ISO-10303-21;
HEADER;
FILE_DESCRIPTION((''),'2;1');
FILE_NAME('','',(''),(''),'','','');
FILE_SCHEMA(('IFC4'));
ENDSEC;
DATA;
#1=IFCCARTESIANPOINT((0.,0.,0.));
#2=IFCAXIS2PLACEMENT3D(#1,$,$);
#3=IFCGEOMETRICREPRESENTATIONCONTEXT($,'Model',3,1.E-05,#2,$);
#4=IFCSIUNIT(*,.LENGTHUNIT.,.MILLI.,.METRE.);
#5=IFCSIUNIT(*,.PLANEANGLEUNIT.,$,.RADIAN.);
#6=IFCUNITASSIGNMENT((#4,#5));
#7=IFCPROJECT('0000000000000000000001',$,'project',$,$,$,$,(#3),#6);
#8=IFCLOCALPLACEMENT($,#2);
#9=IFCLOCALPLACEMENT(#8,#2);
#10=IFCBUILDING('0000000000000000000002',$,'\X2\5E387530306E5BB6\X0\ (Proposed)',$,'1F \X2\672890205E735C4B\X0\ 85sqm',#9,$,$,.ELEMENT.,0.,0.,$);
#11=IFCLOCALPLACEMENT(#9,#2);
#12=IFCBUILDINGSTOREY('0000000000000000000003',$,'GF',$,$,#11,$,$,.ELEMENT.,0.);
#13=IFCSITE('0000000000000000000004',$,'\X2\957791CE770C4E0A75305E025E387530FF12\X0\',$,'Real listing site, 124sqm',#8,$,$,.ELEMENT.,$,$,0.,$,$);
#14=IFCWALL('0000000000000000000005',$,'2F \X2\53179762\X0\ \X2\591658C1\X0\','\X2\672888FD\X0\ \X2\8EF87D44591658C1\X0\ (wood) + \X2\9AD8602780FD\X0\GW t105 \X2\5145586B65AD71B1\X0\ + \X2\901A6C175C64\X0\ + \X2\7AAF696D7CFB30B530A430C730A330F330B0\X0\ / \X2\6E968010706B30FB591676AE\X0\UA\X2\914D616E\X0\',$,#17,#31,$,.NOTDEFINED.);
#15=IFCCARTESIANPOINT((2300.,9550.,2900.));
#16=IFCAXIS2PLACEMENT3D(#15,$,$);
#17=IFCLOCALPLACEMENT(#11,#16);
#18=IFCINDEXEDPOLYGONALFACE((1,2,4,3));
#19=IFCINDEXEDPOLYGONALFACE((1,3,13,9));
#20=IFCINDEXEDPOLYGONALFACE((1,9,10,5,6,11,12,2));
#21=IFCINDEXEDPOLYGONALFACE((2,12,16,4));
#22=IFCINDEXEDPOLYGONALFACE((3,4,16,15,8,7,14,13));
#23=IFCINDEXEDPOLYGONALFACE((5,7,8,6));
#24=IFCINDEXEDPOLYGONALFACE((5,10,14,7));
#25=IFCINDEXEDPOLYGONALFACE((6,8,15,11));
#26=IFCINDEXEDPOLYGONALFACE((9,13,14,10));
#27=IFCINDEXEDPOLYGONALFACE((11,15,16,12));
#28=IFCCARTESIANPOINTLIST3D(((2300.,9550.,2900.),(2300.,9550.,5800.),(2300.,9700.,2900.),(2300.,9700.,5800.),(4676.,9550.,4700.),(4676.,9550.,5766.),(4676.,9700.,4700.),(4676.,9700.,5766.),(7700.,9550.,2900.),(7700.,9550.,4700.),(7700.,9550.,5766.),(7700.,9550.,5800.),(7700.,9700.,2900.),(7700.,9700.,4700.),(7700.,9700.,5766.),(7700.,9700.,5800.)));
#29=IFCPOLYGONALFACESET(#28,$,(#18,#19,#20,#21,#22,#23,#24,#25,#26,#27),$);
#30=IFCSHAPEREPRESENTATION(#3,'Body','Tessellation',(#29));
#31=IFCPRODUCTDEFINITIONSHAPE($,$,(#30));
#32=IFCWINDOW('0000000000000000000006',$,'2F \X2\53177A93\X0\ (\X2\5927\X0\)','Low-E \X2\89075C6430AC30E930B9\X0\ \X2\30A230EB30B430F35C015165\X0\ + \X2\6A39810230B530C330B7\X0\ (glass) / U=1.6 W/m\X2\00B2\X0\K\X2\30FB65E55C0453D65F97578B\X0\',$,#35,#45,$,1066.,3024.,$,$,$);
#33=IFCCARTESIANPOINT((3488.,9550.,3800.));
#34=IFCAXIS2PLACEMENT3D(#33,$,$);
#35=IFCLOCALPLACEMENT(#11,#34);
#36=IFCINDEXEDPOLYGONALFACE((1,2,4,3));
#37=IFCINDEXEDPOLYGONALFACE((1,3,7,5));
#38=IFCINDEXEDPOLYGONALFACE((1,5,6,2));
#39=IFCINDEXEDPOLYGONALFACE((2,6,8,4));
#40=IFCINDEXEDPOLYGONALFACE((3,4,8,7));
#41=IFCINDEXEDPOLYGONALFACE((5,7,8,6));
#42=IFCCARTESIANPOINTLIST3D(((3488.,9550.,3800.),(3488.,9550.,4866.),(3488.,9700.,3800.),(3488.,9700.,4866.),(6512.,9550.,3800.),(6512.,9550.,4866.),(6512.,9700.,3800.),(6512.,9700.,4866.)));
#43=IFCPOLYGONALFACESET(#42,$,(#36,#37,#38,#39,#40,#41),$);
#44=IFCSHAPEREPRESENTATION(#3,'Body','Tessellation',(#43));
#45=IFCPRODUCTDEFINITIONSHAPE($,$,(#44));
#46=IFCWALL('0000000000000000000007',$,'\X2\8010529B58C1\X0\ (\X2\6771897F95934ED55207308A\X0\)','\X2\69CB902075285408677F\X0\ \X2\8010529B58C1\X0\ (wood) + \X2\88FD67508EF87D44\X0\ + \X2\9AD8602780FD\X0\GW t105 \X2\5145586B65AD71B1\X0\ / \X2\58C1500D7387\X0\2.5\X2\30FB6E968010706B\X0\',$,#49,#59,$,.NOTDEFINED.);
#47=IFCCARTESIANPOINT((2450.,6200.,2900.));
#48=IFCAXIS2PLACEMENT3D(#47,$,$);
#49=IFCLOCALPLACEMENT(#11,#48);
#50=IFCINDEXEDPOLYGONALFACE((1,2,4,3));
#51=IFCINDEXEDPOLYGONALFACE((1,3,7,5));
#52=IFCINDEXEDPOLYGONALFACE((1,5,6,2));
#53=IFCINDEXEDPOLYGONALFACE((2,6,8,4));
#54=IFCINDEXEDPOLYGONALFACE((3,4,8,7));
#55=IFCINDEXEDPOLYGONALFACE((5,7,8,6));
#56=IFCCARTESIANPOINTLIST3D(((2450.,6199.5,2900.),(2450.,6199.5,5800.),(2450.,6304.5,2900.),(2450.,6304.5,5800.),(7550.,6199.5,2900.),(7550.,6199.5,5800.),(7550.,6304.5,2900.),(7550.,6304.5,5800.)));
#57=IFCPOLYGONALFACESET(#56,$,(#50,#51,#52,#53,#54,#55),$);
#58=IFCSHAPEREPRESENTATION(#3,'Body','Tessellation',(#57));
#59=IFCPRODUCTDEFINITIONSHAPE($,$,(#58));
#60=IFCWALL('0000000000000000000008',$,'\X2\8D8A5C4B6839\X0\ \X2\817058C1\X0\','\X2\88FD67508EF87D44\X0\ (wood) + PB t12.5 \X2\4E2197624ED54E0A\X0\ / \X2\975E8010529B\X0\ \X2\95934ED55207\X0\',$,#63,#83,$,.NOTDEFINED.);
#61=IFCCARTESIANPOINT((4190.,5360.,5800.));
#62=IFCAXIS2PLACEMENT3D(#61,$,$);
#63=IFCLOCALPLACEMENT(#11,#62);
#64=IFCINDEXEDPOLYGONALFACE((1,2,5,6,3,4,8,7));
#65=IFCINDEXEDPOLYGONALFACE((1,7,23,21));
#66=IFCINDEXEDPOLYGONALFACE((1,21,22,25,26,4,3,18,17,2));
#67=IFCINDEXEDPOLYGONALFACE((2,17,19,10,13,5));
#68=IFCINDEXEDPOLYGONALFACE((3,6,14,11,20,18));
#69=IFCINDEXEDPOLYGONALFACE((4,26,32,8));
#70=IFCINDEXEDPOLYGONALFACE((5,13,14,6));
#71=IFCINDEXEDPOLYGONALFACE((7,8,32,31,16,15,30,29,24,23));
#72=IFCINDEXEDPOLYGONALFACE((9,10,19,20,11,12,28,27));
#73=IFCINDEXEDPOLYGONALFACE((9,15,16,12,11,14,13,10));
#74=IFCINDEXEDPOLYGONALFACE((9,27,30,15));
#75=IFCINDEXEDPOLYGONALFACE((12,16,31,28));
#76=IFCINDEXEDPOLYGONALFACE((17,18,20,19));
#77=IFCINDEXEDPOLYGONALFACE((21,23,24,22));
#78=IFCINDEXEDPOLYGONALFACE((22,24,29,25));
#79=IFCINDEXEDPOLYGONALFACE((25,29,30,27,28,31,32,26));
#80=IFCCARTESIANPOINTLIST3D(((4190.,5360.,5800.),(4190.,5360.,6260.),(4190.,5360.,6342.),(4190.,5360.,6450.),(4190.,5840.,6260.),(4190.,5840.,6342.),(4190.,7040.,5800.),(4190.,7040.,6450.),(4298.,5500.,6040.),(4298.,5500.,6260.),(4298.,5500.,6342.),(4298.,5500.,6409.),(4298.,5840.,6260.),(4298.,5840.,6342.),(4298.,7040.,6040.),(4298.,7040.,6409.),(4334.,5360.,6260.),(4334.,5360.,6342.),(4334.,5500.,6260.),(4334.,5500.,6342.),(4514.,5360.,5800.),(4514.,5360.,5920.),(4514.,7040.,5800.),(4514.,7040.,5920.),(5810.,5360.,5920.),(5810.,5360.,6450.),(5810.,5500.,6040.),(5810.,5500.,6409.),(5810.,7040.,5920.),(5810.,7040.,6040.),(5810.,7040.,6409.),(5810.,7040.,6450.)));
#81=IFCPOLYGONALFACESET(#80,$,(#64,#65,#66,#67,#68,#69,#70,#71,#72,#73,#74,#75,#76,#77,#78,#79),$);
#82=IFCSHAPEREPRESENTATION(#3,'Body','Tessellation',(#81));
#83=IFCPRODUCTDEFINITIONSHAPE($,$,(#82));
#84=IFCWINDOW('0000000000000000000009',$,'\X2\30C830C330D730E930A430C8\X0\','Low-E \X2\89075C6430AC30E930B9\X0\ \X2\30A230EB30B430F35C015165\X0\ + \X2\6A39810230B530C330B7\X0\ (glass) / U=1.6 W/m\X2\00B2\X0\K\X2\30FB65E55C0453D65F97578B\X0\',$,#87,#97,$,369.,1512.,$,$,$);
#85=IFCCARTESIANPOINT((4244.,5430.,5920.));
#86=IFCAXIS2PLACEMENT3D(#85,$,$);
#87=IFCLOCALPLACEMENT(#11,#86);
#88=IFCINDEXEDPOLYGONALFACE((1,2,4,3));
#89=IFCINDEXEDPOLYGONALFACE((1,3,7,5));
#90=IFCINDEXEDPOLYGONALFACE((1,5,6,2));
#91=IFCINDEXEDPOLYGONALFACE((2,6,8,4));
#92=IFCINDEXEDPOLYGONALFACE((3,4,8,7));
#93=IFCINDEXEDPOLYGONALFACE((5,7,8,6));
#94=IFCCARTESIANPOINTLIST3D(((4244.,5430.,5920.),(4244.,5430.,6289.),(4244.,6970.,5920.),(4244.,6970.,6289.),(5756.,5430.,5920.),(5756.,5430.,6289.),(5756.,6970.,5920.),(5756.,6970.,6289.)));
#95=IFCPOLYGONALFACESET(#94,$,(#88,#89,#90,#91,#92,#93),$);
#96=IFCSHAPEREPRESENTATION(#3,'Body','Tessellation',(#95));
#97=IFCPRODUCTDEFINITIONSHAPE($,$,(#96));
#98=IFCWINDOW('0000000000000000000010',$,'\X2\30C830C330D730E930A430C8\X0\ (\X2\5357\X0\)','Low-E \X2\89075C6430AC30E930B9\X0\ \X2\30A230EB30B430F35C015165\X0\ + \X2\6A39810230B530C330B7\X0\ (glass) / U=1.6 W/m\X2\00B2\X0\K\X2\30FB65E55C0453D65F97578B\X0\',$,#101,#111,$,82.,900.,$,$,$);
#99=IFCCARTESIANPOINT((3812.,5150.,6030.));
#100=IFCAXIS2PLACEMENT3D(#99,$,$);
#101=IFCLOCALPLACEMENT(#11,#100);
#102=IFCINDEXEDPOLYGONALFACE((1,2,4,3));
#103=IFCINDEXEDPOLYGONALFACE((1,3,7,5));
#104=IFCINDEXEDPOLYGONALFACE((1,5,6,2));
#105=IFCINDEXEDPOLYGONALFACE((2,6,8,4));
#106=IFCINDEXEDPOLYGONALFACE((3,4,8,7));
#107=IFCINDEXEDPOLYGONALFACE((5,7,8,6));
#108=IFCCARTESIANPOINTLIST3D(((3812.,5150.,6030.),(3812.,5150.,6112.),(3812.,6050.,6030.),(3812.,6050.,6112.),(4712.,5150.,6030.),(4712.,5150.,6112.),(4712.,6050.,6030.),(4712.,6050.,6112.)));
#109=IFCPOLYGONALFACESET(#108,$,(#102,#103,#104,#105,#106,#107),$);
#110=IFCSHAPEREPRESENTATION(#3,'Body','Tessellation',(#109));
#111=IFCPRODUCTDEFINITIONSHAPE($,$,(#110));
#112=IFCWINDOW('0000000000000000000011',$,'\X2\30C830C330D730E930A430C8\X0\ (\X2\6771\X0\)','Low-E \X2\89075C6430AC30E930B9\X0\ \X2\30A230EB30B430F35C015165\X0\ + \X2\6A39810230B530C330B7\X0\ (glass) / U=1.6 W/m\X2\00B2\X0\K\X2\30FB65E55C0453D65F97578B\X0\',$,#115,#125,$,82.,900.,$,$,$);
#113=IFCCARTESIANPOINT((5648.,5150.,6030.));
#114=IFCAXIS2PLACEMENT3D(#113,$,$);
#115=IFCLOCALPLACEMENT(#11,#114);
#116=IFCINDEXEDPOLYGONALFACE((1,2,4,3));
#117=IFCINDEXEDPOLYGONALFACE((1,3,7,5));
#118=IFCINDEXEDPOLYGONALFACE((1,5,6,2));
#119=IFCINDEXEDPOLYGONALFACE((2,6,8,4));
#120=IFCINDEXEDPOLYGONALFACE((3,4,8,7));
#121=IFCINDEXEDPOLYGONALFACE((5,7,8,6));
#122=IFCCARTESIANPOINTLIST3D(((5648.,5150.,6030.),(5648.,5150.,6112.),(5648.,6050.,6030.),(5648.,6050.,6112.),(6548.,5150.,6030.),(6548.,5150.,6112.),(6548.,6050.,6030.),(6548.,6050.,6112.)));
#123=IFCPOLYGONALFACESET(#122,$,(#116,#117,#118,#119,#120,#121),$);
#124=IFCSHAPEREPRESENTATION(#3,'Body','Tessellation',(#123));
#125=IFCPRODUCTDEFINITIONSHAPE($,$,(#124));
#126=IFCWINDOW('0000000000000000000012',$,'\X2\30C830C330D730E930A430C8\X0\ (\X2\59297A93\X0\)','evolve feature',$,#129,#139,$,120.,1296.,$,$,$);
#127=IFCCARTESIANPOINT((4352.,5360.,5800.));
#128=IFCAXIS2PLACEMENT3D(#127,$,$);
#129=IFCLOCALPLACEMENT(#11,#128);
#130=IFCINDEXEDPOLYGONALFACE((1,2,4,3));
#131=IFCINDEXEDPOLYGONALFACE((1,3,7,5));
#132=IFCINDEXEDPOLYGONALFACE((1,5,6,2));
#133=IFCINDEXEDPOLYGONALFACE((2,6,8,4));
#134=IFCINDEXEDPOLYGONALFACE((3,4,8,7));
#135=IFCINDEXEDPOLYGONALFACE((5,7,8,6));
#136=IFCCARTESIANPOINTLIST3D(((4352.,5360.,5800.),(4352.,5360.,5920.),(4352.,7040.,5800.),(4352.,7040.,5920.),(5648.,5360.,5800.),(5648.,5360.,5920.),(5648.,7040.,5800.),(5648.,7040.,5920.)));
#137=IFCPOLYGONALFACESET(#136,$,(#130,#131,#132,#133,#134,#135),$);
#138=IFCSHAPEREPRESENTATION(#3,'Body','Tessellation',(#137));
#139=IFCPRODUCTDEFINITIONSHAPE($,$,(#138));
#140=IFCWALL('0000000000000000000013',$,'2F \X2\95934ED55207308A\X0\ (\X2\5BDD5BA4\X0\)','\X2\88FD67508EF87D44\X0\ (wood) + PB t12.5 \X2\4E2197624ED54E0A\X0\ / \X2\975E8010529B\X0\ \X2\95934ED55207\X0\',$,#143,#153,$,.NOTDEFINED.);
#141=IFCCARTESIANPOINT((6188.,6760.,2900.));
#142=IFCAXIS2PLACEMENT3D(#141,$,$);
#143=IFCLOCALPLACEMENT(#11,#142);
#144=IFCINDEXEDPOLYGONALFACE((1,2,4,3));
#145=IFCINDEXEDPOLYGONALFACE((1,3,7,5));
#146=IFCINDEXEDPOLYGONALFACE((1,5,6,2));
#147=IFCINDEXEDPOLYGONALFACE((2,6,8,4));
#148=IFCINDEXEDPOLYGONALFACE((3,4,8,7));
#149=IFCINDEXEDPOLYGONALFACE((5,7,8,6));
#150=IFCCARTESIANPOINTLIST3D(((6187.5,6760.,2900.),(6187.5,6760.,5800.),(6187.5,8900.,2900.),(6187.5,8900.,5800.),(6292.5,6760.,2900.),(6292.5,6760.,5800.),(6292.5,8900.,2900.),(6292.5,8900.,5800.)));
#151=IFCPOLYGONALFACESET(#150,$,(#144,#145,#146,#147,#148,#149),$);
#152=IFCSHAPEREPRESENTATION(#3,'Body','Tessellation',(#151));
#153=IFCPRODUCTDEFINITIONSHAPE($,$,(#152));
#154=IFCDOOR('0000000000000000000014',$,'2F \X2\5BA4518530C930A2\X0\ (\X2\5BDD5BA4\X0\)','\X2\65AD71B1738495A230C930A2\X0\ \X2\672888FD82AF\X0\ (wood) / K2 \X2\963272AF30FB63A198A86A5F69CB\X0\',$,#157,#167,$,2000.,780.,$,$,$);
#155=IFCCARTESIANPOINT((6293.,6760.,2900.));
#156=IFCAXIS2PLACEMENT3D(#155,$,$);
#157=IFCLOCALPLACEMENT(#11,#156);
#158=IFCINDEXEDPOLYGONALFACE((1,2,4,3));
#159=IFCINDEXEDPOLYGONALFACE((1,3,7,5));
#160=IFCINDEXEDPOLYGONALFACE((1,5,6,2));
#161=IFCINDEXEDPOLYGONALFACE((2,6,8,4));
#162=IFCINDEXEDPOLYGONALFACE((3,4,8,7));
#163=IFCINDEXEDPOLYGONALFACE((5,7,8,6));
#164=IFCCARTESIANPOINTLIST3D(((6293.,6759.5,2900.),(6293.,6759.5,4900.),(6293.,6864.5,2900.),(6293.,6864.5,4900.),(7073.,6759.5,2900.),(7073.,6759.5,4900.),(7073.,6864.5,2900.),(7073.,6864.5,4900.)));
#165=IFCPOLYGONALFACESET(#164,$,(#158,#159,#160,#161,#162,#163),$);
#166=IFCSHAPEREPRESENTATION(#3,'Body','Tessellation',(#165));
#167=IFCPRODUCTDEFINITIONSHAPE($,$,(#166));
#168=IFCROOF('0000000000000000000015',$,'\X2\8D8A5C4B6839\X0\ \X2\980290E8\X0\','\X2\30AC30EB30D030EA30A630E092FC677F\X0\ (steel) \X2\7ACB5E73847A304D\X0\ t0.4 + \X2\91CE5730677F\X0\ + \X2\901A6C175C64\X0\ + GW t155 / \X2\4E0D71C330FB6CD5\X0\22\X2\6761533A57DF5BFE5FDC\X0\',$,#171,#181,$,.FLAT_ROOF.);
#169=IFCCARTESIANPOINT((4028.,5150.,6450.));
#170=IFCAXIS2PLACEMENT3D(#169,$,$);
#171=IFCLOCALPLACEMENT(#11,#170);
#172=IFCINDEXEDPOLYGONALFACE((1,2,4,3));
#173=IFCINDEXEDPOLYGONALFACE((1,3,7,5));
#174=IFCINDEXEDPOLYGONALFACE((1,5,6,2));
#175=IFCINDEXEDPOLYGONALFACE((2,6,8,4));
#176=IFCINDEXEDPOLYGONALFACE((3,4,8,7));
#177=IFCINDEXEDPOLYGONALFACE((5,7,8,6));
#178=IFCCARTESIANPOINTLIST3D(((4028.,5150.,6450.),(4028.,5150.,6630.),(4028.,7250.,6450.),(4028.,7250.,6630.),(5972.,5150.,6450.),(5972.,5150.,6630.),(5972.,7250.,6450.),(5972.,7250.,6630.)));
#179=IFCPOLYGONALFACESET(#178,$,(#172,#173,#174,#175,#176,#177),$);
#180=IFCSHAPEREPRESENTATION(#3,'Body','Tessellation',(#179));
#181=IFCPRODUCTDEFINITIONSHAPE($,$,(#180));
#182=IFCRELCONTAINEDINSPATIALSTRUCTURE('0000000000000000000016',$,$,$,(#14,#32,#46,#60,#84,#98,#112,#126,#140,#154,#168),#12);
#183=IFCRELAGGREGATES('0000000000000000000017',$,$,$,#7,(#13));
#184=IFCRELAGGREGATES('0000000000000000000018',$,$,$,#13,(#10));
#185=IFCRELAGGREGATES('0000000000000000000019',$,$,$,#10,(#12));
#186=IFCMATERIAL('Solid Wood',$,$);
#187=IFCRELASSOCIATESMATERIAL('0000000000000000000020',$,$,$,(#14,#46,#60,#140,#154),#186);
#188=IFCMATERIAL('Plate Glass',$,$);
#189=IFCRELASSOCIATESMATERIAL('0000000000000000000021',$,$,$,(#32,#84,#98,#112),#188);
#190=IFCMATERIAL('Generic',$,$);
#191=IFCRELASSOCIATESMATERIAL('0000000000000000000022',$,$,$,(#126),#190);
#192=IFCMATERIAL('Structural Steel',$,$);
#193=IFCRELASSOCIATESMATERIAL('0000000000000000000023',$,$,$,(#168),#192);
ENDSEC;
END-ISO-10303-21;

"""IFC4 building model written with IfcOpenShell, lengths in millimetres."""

from ifc_helpers import new_model, si_unit, frame, frame_2d, origin, place, context, project, spatial, rectangle, extrude, material, element, fill, save


model = new_model("IFC4")

# Units and contexts
model_context = context("Model", 3, precision=1e-05, world=origin())
ifc_project = project(units=[si_unit("LENGTHUNIT", "METRE", prefix="MILLI"), si_unit("PLANEANGLEUNIT", "RADIAN")], contexts=[model_context])

# Site, building, storey
site_placement = place(None, origin())
site = spatial("IfcSite", under=ifc_project, at=site_placement, Name="長野県上田市常田２", ObjectType="Real listing site, 124sqm", CompositionType="ELEMENT", RefElevation=0.0)
building_placement = place(site_placement, origin())
building = spatial("IfcBuilding", under=site, at=building_placement, Name="常田の家 (Proposed)", ObjectType="1F 木造平屋 85sqm", CompositionType="ELEMENT", ElevationOfRefHeight=0.0, ElevationOfTerrain=0.0)
storey_placement = place(building_placement, origin())
storey = spatial("IfcBuildingStorey", under=building, at=storey_placement, Name="GF", CompositionType="ELEMENT", Elevation=0.0)

# Wall, opening, window
ifc_material_1 = material(Name="Solid Wood")
wall_1_placement = place(storey_placement, frame((2300.0, 9550.0, 2900.0)))
wall_1 = element("IfcWall", 1, at=wall_1_placement, inside=storey, material=ifc_material_1, Name="2F 北面 外壁", Description="木製 軸組外壁 (wood) + 高性能GW t105 充填断熱 + 通気層 + 窯業系サイディング / 準耐火・外皮UA配慮", PredefinedType="NOTDEFINED", context=model_context, shape_type="SweptSolid", body=[
    extrude(rectangle(XDim=5400.0, YDim=150.0, at=frame_2d((2700.0, 75.0))), frame((2300.0, 9550.0, 2900.0)), (0.0, 0.0, 1.0), 2900.0),
])
opening_1_placement = place(storey_placement, frame((3488.0, 9550.0, 3800.0)))
opening_1 = element("IfcOpeningElement", 2, at=opening_1_placement, cuts=wall_1, PredefinedType="NOTDEFINED", context=model_context, shape_type="SweptSolid", body=[
    extrude(rectangle(XDim=3024.0, YDim=150.0, at=frame_2d((1512.0, 75.0))), frame((3488.0, 9550.0, 3800.0)), (0.0, 0.0, 1.0), 1066.0),
])
ifc_material_2 = material(Name="Plate Glass")
window_1_placement = place(storey_placement, frame((3488.0, 9550.0, 3800.0)))
window_1 = element("IfcWindow", 3, at=window_1_placement, inside=storey, material=ifc_material_2, Name="2F 北窓 (大)", Description="Low-E 複層ガラス アルゴン封入 + 樹脂サッシ (glass) / U=1.6 W/m²K・日射取得型", OverallHeight=1066.0, OverallWidth=3024.0, context=model_context, shape_type="SweptSolid", body=[
    extrude(rectangle(XDim=3024.0, YDim=150.0, at=frame_2d((1512.0, 75.0))), frame((3488.0, 9550.0, 3800.0)), (0.0, 0.0, 1.0), 1066.0),
])
fill(opening_1, window_1)

# Wall
wall_2_placement = place(storey_placement, frame((2450.0, 6200.0, 2900.0)))
element("IfcWall", 4, at=wall_2_placement, inside=storey, material=ifc_material_1, Name="耐力壁 (東西間仕切り)", Description="構造用合板 耐力壁 (wood) + 製材軸組 + 高性能GW t105 充填断熱 / 壁倍率2.5・準耐火", PredefinedType="NOTDEFINED", context=model_context, shape_type="SweptSolid", body=[
    extrude(rectangle(XDim=5100.0, YDim=105.0, at=frame_2d((2550.0, 52.0))), frame((2450.0, 6200.0, 2900.0)), (0.0, 0.0, 1.0), 2900.0),
])

# Wall, openings, windows
wall_3_placement = place(storey_placement, frame((4190.0, 5360.0, 5800.0)))
wall_3 = element("IfcWall", 5, at=wall_3_placement, inside=storey, material=ifc_material_1, Name="越屋根 腰壁", Description="製材軸組 (wood) + PB t12.5 両面仕上 / 非耐力 間仕切", PredefinedType="NOTDEFINED", context=model_context, shape_type="SweptSolid", body=[
    extrude(rectangle(XDim=1620.0, YDim=1680.0, at=frame_2d((810.0, 840.0))), frame((4190.0, 5360.0, 5800.0)), (0.0, 0.0, 1.0), 650.0),
])
opening_2_placement = place(storey_placement, frame((4244.0, 5430.0, 5920.0)))
opening_2 = element("IfcOpeningElement", 6, at=opening_2_placement, cuts=wall_3, PredefinedType="NOTDEFINED", context=model_context, shape_type="SweptSolid", body=[
    extrude(rectangle(XDim=1512.0, YDim=1540.0, at=frame_2d((756.0, 770.0))), frame((4244.0, 5430.0, 5920.0)), (0.0, 0.0, 1.0), 369.0),
])
opening_3_placement = place(storey_placement, frame((3812.0, 5150.0, 6030.0)))
opening_3 = element("IfcOpeningElement", 7, at=opening_3_placement, cuts=wall_3, PredefinedType="NOTDEFINED", context=model_context, shape_type="SweptSolid", body=[
    extrude(rectangle(XDim=900.0, YDim=900.0, at=frame_2d((450.0, 450.0))), frame((3812.0, 5150.0, 6030.0)), (0.0, 0.0, 1.0), 82.0),
])
opening_4_placement = place(storey_placement, frame((5648.0, 5150.0, 6030.0)))
opening_4 = element("IfcOpeningElement", 8, at=opening_4_placement, cuts=wall_3, PredefinedType="NOTDEFINED", context=model_context, shape_type="SweptSolid", body=[
    extrude(rectangle(XDim=900.0, YDim=900.0, at=frame_2d((450.0, 450.0))), frame((5648.0, 5150.0, 6030.0)), (0.0, 0.0, 1.0), 82.0),
])
opening_5_placement = place(storey_placement, frame((4352.0, 5360.0, 5800.0)))
opening_5 = element("IfcOpeningElement", 9, at=opening_5_placement, cuts=wall_3, PredefinedType="NOTDEFINED", context=model_context, shape_type="SweptSolid", body=[
    extrude(rectangle(XDim=1296.0, YDim=1680.0, at=frame_2d((648.0, 840.0))), frame((4352.0, 5360.0, 5800.0)), (0.0, 0.0, 1.0), 120.0),
])
window_2_placement = place(storey_placement, frame((4244.0, 5430.0, 5920.0)))
window_2 = element("IfcWindow", 10, at=window_2_placement, inside=storey, material=ifc_material_2, Name="トップライト", Description="Low-E 複層ガラス アルゴン封入 + 樹脂サッシ (glass) / U=1.6 W/m²K・日射取得型", OverallHeight=369.0, OverallWidth=1512.0, context=model_context, shape_type="SweptSolid", body=[
    extrude(rectangle(XDim=1512.0, YDim=1540.0, at=frame_2d((756.0, 770.0))), frame((4244.0, 5430.0, 5920.0)), (0.0, 0.0, 1.0), 369.0),
])
fill(opening_2, window_2)
window_3_placement = place(storey_placement, frame((3812.0, 5150.0, 6030.0)))
window_3 = element("IfcWindow", 11, at=window_3_placement, inside=storey, material=ifc_material_2, Name="トップライト (南)", Description="Low-E 複層ガラス アルゴン封入 + 樹脂サッシ (glass) / U=1.6 W/m²K・日射取得型", OverallHeight=82.0, OverallWidth=900.0, context=model_context, shape_type="SweptSolid", body=[
    extrude(rectangle(XDim=900.0, YDim=900.0, at=frame_2d((450.0, 450.0))), frame((3812.0, 5150.0, 6030.0)), (0.0, 0.0, 1.0), 82.0),
])
fill(opening_3, window_3)
window_4_placement = place(storey_placement, frame((5648.0, 5150.0, 6030.0)))
window_4 = element("IfcWindow", 12, at=window_4_placement, inside=storey, material=ifc_material_2, Name="トップライト (東)", Description="Low-E 複層ガラス アルゴン封入 + 樹脂サッシ (glass) / U=1.6 W/m²K・日射取得型", OverallHeight=82.0, OverallWidth=900.0, context=model_context, shape_type="SweptSolid", body=[
    extrude(rectangle(XDim=900.0, YDim=900.0, at=frame_2d((450.0, 450.0))), frame((5648.0, 5150.0, 6030.0)), (0.0, 0.0, 1.0), 82.0),
])
fill(opening_4, window_4)
ifc_material_3 = material(Name="Generic")
window_5_placement = place(storey_placement, frame((4352.0, 5360.0, 5800.0)))
window_5 = element("IfcWindow", 13, at=window_5_placement, inside=storey, material=ifc_material_3, Name="トップライト (天窓)", Description="evolve feature", OverallHeight=120.0, OverallWidth=1296.0, context=model_context, shape_type="SweptSolid", body=[
    extrude(rectangle(XDim=1296.0, YDim=1680.0, at=frame_2d((648.0, 840.0))), frame((4352.0, 5360.0, 5800.0)), (0.0, 0.0, 1.0), 120.0),
])
fill(opening_5, window_5)

# Wall
wall_4_placement = place(storey_placement, frame((6188.0, 6760.0, 2900.0)))
element("IfcWall", 14, at=wall_4_placement, inside=storey, material=ifc_material_1, Name="2F 間仕切り (寝室)", Description="製材軸組 (wood) + PB t12.5 両面仕上 / 非耐力 間仕切", PredefinedType="NOTDEFINED", context=model_context, shape_type="SweptSolid", body=[
    extrude(rectangle(XDim=105.0, YDim=2140.0, at=frame_2d((52.0, 1070.0))), frame((6188.0, 6760.0, 2900.0)), (0.0, 0.0, 1.0), 2900.0),
])

# Door
door_placement = place(storey_placement, frame((6293.0, 6760.0, 2900.0)))
element("IfcDoor", 15, at=door_placement, inside=storey, material=ifc_material_1, Name="2F 室内ドア (寝室)", Description="断熱玄関ドア 木製芯 (wood) / K2 防犯・採風機構", OverallHeight=2000.0, OverallWidth=780.0, context=model_context, shape_type="SweptSolid", body=[
    extrude(rectangle(XDim=780.0, YDim=105.0, at=frame_2d((390.0, 52.0))), frame((6293.0, 6760.0, 2900.0)), (0.0, 0.0, 1.0), 2000.0),
])

# Roof
ifc_material_4 = material(Name="Structural Steel")
roof_placement = place(storey_placement, frame((4028.0, 5150.0, 6450.0)))
element("IfcRoof", 16, at=roof_placement, inside=storey, material=ifc_material_4, Name="越屋根 頂部", Description="ガルバリウム鋼板 (steel) 立平葺き t0.4 + 野地板 + 通気層 + GW t155 / 不燃・法22条区域対応", PredefinedType="FLAT_ROOF", context=model_context, shape_type="SweptSolid", body=[
    extrude(rectangle(XDim=1944.0, YDim=2100.0, at=frame_2d((972.0, 1050.0))), frame((4028.0, 5150.0, 6450.0)), (0.0, 0.0, 1.0), 180.0),
])

save(model, "model.ifc")
